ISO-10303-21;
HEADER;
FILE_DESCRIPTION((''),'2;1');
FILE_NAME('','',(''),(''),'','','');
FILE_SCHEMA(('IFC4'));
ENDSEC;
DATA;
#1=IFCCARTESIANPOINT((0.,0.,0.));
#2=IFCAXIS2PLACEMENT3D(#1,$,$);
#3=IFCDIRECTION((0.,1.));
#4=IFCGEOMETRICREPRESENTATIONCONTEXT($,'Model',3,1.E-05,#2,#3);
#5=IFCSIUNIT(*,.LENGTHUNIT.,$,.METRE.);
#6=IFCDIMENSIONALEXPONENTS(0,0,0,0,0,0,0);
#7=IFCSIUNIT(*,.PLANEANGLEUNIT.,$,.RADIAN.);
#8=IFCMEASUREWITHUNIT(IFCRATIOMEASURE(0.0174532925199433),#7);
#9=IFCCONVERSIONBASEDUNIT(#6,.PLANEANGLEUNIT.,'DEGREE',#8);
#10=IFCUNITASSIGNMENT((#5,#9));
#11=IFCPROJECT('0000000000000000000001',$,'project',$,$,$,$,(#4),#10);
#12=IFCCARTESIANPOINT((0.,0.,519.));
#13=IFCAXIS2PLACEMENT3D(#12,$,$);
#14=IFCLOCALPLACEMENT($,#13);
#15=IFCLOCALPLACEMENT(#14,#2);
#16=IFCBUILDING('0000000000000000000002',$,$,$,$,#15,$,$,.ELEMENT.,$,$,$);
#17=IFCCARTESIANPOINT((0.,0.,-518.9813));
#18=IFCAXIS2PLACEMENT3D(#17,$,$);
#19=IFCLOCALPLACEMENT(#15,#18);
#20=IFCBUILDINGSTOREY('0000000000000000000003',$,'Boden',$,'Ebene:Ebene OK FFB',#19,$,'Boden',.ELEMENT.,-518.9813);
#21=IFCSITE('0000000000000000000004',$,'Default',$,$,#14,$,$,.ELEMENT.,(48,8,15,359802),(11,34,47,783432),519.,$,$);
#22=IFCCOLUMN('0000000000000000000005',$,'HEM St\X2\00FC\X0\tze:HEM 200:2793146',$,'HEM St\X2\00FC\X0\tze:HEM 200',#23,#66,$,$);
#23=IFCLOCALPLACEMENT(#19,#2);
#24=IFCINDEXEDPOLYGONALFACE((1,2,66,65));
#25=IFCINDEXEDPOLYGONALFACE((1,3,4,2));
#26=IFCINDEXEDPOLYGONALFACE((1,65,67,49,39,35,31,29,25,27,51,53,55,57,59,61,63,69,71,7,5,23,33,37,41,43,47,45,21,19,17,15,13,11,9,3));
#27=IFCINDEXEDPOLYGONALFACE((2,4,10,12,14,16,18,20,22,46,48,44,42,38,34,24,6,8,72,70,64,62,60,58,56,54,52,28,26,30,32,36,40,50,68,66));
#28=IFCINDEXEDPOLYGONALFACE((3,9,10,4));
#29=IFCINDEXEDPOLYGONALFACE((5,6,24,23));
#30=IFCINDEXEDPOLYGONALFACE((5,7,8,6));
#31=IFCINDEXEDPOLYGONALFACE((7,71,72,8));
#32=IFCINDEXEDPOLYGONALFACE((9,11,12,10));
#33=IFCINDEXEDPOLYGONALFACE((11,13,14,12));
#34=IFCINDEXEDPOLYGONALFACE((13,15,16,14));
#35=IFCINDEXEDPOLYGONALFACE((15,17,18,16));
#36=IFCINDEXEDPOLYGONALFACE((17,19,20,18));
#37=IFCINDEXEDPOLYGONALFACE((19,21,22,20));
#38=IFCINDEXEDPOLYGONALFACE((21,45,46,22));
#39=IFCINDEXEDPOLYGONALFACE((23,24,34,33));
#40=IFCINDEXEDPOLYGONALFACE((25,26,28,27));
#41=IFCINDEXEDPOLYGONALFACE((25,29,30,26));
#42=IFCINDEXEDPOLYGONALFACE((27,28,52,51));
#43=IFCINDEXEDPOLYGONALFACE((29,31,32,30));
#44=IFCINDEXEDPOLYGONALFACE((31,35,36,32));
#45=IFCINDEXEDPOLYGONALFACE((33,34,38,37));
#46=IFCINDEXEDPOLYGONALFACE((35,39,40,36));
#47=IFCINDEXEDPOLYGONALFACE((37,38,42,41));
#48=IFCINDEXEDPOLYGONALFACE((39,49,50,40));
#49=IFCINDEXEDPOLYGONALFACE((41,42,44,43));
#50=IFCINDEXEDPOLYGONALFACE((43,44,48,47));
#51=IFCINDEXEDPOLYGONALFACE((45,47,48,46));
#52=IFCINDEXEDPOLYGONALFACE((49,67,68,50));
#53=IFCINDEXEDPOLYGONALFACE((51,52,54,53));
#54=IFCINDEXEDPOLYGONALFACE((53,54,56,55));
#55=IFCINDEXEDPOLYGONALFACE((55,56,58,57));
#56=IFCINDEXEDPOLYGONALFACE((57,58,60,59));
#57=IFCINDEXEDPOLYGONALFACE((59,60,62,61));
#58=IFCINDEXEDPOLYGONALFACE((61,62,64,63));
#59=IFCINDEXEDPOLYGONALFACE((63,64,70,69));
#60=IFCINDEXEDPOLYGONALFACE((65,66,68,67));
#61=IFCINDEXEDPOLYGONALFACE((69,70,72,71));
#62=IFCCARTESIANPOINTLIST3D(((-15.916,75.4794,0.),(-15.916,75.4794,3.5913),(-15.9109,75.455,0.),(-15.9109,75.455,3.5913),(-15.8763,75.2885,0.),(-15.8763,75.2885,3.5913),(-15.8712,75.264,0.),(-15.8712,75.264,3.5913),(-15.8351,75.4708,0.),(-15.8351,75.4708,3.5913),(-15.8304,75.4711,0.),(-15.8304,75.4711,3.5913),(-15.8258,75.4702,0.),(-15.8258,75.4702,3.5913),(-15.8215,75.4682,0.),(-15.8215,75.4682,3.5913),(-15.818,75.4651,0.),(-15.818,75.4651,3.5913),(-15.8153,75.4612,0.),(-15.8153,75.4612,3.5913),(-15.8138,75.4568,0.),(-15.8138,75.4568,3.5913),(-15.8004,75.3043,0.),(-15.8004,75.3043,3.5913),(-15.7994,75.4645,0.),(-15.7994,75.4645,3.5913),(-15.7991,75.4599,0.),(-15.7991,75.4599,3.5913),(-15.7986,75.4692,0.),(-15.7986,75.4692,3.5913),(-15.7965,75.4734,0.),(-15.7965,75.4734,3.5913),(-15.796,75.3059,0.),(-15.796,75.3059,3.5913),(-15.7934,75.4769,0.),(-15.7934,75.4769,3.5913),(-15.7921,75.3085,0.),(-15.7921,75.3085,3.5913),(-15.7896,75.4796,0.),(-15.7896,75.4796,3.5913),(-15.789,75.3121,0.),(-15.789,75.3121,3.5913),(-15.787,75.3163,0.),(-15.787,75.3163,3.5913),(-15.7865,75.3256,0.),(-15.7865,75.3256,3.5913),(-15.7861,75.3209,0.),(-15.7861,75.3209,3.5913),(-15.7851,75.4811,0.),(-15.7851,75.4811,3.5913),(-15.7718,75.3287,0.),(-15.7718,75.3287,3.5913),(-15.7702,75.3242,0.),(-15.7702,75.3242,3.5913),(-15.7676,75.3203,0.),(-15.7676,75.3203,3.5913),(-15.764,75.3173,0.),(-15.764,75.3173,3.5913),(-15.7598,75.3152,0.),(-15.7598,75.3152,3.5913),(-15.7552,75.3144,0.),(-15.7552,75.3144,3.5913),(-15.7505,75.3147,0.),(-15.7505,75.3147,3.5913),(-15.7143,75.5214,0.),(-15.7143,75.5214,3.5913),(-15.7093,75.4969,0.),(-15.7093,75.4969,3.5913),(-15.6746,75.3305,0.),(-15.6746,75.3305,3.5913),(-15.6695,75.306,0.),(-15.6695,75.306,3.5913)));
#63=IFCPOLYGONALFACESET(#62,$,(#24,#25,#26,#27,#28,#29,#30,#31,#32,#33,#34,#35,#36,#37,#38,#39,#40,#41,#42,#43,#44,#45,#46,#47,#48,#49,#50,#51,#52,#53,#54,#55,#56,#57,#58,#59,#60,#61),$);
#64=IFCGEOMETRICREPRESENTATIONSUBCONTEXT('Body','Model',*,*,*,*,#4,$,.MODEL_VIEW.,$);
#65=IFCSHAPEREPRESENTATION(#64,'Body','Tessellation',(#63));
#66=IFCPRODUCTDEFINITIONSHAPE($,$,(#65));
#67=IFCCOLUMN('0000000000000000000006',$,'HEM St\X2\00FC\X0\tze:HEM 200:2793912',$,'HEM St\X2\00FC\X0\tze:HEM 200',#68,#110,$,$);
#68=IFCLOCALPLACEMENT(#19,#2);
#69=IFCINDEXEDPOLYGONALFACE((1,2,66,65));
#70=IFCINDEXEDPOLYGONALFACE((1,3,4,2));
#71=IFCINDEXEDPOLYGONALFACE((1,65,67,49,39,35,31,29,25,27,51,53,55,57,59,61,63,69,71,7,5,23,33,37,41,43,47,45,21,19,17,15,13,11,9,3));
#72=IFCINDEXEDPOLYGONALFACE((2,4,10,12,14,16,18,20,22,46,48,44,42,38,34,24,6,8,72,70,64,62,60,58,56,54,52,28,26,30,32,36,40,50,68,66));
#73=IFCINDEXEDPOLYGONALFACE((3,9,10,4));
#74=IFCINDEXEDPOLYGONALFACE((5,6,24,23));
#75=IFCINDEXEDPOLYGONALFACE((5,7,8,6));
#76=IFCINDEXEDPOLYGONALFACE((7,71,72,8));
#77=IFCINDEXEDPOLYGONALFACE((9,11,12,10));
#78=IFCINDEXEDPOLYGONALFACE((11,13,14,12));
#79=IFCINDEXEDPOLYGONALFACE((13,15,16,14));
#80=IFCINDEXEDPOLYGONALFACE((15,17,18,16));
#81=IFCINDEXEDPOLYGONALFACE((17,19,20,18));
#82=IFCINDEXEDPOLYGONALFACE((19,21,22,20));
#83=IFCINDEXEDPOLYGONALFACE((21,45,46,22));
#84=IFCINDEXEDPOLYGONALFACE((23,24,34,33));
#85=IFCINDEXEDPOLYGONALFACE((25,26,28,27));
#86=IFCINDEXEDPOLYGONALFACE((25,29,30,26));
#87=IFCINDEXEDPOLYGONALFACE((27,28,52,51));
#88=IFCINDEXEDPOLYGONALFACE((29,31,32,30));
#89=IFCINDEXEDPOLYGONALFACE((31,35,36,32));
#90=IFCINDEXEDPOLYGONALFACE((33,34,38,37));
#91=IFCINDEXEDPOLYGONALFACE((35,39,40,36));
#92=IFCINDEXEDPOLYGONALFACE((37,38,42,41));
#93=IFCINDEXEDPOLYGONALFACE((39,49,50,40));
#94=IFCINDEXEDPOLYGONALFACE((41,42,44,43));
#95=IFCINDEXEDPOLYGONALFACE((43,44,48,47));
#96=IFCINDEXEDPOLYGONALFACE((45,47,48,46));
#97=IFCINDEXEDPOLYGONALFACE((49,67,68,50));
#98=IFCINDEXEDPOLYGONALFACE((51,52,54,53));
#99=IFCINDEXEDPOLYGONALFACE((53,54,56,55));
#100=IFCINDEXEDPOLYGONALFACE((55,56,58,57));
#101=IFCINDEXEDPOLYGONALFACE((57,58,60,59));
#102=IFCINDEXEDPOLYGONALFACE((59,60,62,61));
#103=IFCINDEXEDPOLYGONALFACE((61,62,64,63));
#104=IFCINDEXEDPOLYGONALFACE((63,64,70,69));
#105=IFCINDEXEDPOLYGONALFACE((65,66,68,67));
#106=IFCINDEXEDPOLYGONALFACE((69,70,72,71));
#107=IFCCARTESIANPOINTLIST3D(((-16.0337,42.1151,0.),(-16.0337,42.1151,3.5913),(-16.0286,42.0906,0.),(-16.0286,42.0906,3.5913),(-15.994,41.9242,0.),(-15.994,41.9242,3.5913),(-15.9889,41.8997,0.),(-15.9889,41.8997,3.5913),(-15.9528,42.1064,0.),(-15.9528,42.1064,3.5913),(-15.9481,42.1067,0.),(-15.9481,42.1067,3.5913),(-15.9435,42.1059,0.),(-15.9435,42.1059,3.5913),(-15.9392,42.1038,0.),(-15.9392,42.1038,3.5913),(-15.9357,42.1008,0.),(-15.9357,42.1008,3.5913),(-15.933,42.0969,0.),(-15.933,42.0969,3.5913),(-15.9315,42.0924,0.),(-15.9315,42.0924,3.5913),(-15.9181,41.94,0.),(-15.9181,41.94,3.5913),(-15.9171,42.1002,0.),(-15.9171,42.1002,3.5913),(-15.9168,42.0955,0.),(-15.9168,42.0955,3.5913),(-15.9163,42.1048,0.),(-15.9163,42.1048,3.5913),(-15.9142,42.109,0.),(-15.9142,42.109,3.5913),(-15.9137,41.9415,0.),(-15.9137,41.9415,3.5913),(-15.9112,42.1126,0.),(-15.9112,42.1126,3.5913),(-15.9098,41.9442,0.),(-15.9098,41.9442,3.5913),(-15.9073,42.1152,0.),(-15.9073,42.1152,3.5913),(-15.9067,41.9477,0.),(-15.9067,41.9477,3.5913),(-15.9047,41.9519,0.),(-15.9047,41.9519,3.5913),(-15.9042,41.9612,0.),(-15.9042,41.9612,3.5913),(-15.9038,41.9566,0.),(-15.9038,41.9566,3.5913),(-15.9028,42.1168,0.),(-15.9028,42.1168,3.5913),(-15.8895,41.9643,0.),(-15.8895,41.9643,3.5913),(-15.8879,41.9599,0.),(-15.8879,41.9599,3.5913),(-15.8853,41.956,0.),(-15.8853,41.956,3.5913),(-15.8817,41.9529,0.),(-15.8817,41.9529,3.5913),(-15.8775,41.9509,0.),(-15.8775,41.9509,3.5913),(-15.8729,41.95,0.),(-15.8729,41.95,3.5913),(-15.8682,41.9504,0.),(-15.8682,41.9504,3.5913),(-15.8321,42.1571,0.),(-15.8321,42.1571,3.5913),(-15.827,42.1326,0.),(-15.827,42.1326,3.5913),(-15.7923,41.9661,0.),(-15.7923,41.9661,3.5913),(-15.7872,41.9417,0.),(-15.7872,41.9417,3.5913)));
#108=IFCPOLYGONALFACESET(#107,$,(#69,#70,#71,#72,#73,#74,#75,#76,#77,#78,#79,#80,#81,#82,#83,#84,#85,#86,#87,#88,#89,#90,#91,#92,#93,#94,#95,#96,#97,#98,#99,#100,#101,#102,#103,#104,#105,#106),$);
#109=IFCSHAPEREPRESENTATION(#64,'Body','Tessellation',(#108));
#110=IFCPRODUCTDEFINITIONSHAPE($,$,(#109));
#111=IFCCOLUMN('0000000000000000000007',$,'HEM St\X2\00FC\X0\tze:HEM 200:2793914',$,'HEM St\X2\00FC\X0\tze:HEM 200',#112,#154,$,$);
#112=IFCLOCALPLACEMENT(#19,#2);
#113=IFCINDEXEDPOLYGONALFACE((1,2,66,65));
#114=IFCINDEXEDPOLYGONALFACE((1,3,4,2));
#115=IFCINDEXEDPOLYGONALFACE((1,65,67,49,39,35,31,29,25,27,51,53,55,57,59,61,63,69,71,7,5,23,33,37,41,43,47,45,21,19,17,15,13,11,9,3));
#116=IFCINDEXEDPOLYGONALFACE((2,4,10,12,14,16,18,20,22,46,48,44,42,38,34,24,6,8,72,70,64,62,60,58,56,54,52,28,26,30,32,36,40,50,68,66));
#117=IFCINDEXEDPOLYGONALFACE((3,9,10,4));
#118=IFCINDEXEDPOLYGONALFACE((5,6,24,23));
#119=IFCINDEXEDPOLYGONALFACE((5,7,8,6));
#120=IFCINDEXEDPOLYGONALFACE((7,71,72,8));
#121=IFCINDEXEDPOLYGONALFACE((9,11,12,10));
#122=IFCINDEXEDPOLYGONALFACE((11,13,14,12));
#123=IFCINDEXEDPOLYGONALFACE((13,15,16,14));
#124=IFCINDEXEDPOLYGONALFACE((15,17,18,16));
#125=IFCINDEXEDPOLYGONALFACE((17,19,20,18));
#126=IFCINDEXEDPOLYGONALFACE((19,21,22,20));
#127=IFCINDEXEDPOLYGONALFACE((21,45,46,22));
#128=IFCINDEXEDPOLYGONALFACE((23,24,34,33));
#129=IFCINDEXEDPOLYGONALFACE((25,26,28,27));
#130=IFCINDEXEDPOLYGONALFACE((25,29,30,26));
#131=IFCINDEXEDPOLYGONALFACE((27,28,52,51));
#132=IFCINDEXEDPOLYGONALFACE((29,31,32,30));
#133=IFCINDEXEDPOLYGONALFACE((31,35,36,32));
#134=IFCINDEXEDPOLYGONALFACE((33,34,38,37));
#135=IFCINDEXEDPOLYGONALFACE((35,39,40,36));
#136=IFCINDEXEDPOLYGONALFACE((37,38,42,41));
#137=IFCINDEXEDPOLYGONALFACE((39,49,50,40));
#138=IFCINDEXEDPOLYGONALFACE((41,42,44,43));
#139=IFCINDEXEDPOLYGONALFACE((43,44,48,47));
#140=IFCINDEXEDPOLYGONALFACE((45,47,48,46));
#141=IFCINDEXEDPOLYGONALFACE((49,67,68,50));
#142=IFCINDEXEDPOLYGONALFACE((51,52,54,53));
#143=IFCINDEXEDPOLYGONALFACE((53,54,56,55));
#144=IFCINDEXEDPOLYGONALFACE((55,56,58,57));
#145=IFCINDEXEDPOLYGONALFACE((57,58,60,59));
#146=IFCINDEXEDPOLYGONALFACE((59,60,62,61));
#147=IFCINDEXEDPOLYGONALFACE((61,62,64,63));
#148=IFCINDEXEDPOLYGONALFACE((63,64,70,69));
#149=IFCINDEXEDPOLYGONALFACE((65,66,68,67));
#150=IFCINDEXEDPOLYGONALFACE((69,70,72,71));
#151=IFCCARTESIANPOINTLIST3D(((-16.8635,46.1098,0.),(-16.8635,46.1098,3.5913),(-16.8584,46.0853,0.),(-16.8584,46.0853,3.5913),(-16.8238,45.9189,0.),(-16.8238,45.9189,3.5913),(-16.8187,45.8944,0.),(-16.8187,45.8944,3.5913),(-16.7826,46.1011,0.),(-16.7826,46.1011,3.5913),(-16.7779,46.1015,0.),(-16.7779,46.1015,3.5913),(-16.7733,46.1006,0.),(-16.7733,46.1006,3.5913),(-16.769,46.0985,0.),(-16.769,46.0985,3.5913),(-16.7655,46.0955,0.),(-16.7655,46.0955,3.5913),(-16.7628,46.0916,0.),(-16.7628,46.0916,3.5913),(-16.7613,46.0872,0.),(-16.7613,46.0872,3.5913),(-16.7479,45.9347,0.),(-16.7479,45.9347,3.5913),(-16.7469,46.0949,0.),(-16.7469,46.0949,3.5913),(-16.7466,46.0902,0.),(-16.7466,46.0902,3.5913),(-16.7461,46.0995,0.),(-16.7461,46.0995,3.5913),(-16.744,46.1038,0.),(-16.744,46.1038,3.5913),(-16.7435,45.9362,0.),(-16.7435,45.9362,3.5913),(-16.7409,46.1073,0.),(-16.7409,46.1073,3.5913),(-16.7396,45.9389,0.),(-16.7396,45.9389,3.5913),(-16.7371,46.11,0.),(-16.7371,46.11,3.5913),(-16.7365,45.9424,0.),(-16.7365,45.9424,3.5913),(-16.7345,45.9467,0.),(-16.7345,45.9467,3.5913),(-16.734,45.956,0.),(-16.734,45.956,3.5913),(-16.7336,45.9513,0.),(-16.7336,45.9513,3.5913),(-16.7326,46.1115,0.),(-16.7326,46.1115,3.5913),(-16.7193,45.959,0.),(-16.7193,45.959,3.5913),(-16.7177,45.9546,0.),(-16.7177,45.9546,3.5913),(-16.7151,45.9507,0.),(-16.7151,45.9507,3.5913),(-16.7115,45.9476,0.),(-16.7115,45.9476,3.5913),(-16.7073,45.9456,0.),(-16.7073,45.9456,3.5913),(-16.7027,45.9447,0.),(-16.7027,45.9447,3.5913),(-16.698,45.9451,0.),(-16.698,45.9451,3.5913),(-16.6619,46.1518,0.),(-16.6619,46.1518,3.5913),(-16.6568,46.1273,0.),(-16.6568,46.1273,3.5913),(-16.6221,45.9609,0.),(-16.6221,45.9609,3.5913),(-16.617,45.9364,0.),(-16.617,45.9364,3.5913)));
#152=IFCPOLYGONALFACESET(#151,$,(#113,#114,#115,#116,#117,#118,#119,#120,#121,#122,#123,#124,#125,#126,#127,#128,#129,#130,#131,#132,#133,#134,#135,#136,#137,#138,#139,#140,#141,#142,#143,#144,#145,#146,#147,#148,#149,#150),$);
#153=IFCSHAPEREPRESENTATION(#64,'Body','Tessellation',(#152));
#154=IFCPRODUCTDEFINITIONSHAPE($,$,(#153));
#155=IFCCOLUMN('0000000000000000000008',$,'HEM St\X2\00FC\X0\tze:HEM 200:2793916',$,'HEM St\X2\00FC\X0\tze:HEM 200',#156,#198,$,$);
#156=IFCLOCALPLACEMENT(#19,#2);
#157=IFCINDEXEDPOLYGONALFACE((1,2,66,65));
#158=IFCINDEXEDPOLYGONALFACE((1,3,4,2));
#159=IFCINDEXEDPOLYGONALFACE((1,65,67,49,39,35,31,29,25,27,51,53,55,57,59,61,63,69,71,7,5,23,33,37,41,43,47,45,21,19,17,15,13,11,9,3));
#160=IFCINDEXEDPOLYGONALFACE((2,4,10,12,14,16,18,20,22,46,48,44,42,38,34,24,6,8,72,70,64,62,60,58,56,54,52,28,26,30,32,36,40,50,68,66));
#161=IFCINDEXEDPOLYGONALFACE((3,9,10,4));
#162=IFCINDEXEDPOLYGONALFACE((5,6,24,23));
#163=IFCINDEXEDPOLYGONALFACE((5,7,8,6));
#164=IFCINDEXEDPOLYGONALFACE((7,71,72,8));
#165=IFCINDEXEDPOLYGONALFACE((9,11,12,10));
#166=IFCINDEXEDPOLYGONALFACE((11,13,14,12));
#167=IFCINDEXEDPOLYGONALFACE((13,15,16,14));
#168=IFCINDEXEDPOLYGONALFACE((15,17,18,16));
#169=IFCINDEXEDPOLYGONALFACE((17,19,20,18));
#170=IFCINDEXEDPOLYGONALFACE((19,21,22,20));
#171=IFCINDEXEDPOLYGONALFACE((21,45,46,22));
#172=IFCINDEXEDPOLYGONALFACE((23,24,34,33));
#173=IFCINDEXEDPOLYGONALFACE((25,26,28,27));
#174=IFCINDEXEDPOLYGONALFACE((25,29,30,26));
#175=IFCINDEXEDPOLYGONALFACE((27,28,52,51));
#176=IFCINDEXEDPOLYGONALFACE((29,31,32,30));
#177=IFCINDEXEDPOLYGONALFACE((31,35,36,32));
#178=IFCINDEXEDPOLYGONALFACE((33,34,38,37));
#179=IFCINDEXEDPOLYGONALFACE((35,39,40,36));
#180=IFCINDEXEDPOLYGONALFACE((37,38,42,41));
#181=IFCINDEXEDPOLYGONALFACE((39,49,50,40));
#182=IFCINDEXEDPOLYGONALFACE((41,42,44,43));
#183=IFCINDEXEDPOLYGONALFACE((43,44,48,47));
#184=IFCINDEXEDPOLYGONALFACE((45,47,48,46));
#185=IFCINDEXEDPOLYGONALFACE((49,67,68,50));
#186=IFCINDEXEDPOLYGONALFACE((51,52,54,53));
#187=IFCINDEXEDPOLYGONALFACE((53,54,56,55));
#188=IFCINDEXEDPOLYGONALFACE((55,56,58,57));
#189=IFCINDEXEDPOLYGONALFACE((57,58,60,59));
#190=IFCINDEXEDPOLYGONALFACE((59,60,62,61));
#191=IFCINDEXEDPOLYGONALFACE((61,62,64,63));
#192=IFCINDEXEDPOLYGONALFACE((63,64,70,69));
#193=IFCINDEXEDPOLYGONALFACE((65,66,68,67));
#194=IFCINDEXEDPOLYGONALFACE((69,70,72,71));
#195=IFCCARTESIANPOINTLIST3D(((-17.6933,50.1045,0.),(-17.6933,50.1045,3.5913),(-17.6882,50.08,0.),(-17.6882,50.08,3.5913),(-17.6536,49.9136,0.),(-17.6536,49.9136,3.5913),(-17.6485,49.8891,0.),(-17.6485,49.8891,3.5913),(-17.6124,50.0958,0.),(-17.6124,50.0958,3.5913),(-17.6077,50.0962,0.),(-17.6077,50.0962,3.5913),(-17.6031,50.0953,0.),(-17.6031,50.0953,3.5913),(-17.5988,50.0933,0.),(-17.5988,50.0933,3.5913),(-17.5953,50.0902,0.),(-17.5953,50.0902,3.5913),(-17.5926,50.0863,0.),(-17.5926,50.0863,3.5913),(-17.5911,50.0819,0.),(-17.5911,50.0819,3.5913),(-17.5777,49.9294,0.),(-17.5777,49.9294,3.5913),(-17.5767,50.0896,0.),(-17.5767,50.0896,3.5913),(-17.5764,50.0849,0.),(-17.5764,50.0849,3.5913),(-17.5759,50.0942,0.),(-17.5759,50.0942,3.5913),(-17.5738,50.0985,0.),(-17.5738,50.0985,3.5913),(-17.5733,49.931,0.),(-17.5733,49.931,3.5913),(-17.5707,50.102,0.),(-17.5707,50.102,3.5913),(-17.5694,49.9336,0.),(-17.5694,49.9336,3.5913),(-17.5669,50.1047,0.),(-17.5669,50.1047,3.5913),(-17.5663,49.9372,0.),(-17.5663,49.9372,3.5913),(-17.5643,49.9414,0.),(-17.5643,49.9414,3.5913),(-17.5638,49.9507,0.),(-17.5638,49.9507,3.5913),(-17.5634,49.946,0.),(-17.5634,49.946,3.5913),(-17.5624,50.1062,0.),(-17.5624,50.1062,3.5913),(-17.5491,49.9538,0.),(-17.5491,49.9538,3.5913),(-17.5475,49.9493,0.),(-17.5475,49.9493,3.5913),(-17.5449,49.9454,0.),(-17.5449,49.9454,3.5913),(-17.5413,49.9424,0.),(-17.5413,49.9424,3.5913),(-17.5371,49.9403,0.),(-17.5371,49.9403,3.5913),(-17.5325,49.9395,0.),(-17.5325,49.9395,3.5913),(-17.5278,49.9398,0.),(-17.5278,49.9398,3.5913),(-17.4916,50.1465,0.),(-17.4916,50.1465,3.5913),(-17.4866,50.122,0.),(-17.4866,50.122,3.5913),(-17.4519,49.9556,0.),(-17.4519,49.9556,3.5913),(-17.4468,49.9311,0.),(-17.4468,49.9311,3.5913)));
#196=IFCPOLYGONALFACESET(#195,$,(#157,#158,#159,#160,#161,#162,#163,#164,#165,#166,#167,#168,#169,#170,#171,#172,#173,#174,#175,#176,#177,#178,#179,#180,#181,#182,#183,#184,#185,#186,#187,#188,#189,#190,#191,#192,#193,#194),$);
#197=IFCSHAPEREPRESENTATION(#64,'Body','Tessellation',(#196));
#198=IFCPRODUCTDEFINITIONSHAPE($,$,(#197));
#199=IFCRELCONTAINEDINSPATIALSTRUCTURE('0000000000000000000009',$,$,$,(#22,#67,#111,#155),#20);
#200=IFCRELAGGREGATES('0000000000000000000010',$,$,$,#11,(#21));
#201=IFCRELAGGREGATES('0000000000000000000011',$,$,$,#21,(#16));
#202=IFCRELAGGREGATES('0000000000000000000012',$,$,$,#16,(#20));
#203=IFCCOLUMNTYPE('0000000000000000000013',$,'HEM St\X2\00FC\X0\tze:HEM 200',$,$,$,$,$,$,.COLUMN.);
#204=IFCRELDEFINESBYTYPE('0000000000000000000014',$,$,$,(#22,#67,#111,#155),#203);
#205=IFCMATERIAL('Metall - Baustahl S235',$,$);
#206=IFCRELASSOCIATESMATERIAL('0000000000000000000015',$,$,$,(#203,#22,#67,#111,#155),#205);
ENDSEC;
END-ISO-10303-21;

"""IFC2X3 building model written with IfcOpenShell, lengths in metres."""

from ifc_helpers import new_model, entity, si_unit, converted_unit, direction, frame, frame_2d, origin, place, context, subcontext, project, spatial, polyline, circle_curve, parameter, trimmed, segment, composite_curve, outline, extrude, source, transform, mapped, material, type_object, type_shapes, element, save


model = new_model("IFC2X3")

# Units and contexts
model_context = context("Model", 3, precision=1e-05, world=origin(), true_north=direction((0.0, 1.0)))
body_context = subcontext(model_context, "Body", "Model", "MODEL_VIEW")
ifc_project = project(units=[si_unit("LENGTHUNIT", "METRE"), converted_unit("PLANEANGLEUNIT", "DEGREE", entity("IfcRatioMeasure", 0.0174532925199433), si_unit("PLANEANGLEUNIT", "RADIAN"), dimensions=[0, 0, 0, 0, 0, 0, 0])], contexts=[model_context])

# Site, building, storey
site_placement = place(None, frame((0.0, 0.0, 519.0)))
site = spatial("IfcSite", under=ifc_project, at=site_placement, Name="Default", CompositionType="ELEMENT", RefLatitude=(48, 8, 15, 359802), RefLongitude=(11, 34, 47, 783432), RefElevation=519.0)
building_placement = place(site_placement, origin())
building = spatial("IfcBuilding", under=site, at=building_placement, CompositionType="ELEMENT")
storey_placement = place(building_placement, frame((0.0, 0.0, -518.9813)))
storey = spatial("IfcBuildingStorey", under=building, at=storey_placement, Name="Boden", ObjectType="Ebene:Ebene OK FFB", LongName="Boden", CompositionType="ELEMENT", Elevation=-518.9813)

# Columns
ifc_material = material(Name="Metall - Baustahl S235")
column_type = type_object("IfcColumnType", Name="HEM Stütze:HEM 200", PredefinedType="COLUMN", material=ifc_material)
shared_shape = source(origin(), body_context, "Body", "SweptSolid", [
    extrude(outline(composite_curve([segment(polyline([(0.085, -0.103), (0.11, -0.103)]), True, "CONTINUOUS"), segment(polyline([(0.11, -0.103), (0.11, 0.103)]), True, "CONTINUOUS"), segment(polyline([(0.11, 0.103), (0.085, 0.103)]), True, "CONTINUOUS"), segment(polyline([(0.085, 0.103), (0.085, 0.0255)]), True, "CONTINUOUS"), segment(trimmed(circle_curve(frame_2d((0.067, 0.0255), x_axis=(1.0, 0.0)), 0.018), [parameter(270.0)], [parameter(0.0)], True, "PARAMETER"), False, "CONTINUOUS"), segment(polyline([(0.067, 0.0075), (-0.067, 0.0075)]), True, "CONTINUOUS"), segment(trimmed(circle_curve(frame_2d((-0.067, 0.0255), x_axis=(0.0, -1.0)), 0.018), [parameter(270.0)], [parameter(0.0)], True, "PARAMETER"), False, "CONTINUOUS"), segment(polyline([(-0.085, 0.0255), (-0.085, 0.103)]), True, "CONTINUOUS"), segment(polyline([(-0.085, 0.103), (-0.11, 0.103)]), True, "CONTINUOUS"), segment(polyline([(-0.11, 0.103), (-0.11, -0.103)]), True, "CONTINUOUS"), segment(polyline([(-0.11, -0.103), (-0.085, -0.103)]), True, "CONTINUOUS"), segment(polyline([(-0.085, -0.103), (-0.085, -0.0255)]), True, "CONTINUOUS"), segment(trimmed(circle_curve(frame_2d((-0.067, -0.0255), x_axis=(-1.0, 0.0)), 0.018), [parameter(270.0)], [parameter(0.0)], True, "PARAMETER"), False, "CONTINUOUS"), segment(polyline([(-0.067, -0.0075), (0.067, -0.0075)]), True, "CONTINUOUS"), segment(trimmed(circle_curve(frame_2d((0.067, -0.0255), x_axis=(0.0, 1.0)), 0.018), [parameter(270.0)], [parameter(0.0)], True, "PARAMETER"), False, "CONTINUOUS"), segment(polyline([(0.085, -0.0255), (0.085, -0.103)]), True, "CONTINUOUS")], self_intersect=False)), frame((0.0, 0.0, -518.9813), z_axis=(0.0, 0.0, 1.0), x_axis=(0.0, -1.0, 0.0)), (0.0, 0.0, 1.0), 3.5913),
])
type_shapes(column_type, [shared_shape])
for number, where, z_axis, x_axis, name in (
    (1, (-15.7928, 75.3927, 518.9813), (0.0, 0.0, 1.0), (0.979008, 0.20382, 0.0), "HEM Stütze:HEM 200:2793146"),
    (2, (-15.9105, 42.0284, 518.9813), (0.0, 0.0, 1.0), (0.979008, 0.20382, 0.0), "HEM Stütze:HEM 200:2793912"),
    (3, (-16.7403, 46.0231, 518.9813), (0.0, 0.0, 1.0), (0.979008, 0.20382, 0.0), "HEM Stütze:HEM 200:2793914"),
    (4, (-17.5701, 50.0178, 518.9813), (0.0, 0.0, 1.0), (0.979008, 0.20382, 0.0), "HEM Stütze:HEM 200:2793916"),
):
    element("IfcColumn", number, at=place(storey_placement, frame(where, z_axis=z_axis, x_axis=x_axis)), inside=storey, type_object=column_type, material=ifc_material, Name=name, ObjectType="HEM Stütze:HEM 200", context=body_context, shape_type="MappedRepresentation", body=[
        mapped(shared_shape, transform((0.0, 0.0, 0.0), scale=1.0)),
    ])

save(model, "model.ifc")
